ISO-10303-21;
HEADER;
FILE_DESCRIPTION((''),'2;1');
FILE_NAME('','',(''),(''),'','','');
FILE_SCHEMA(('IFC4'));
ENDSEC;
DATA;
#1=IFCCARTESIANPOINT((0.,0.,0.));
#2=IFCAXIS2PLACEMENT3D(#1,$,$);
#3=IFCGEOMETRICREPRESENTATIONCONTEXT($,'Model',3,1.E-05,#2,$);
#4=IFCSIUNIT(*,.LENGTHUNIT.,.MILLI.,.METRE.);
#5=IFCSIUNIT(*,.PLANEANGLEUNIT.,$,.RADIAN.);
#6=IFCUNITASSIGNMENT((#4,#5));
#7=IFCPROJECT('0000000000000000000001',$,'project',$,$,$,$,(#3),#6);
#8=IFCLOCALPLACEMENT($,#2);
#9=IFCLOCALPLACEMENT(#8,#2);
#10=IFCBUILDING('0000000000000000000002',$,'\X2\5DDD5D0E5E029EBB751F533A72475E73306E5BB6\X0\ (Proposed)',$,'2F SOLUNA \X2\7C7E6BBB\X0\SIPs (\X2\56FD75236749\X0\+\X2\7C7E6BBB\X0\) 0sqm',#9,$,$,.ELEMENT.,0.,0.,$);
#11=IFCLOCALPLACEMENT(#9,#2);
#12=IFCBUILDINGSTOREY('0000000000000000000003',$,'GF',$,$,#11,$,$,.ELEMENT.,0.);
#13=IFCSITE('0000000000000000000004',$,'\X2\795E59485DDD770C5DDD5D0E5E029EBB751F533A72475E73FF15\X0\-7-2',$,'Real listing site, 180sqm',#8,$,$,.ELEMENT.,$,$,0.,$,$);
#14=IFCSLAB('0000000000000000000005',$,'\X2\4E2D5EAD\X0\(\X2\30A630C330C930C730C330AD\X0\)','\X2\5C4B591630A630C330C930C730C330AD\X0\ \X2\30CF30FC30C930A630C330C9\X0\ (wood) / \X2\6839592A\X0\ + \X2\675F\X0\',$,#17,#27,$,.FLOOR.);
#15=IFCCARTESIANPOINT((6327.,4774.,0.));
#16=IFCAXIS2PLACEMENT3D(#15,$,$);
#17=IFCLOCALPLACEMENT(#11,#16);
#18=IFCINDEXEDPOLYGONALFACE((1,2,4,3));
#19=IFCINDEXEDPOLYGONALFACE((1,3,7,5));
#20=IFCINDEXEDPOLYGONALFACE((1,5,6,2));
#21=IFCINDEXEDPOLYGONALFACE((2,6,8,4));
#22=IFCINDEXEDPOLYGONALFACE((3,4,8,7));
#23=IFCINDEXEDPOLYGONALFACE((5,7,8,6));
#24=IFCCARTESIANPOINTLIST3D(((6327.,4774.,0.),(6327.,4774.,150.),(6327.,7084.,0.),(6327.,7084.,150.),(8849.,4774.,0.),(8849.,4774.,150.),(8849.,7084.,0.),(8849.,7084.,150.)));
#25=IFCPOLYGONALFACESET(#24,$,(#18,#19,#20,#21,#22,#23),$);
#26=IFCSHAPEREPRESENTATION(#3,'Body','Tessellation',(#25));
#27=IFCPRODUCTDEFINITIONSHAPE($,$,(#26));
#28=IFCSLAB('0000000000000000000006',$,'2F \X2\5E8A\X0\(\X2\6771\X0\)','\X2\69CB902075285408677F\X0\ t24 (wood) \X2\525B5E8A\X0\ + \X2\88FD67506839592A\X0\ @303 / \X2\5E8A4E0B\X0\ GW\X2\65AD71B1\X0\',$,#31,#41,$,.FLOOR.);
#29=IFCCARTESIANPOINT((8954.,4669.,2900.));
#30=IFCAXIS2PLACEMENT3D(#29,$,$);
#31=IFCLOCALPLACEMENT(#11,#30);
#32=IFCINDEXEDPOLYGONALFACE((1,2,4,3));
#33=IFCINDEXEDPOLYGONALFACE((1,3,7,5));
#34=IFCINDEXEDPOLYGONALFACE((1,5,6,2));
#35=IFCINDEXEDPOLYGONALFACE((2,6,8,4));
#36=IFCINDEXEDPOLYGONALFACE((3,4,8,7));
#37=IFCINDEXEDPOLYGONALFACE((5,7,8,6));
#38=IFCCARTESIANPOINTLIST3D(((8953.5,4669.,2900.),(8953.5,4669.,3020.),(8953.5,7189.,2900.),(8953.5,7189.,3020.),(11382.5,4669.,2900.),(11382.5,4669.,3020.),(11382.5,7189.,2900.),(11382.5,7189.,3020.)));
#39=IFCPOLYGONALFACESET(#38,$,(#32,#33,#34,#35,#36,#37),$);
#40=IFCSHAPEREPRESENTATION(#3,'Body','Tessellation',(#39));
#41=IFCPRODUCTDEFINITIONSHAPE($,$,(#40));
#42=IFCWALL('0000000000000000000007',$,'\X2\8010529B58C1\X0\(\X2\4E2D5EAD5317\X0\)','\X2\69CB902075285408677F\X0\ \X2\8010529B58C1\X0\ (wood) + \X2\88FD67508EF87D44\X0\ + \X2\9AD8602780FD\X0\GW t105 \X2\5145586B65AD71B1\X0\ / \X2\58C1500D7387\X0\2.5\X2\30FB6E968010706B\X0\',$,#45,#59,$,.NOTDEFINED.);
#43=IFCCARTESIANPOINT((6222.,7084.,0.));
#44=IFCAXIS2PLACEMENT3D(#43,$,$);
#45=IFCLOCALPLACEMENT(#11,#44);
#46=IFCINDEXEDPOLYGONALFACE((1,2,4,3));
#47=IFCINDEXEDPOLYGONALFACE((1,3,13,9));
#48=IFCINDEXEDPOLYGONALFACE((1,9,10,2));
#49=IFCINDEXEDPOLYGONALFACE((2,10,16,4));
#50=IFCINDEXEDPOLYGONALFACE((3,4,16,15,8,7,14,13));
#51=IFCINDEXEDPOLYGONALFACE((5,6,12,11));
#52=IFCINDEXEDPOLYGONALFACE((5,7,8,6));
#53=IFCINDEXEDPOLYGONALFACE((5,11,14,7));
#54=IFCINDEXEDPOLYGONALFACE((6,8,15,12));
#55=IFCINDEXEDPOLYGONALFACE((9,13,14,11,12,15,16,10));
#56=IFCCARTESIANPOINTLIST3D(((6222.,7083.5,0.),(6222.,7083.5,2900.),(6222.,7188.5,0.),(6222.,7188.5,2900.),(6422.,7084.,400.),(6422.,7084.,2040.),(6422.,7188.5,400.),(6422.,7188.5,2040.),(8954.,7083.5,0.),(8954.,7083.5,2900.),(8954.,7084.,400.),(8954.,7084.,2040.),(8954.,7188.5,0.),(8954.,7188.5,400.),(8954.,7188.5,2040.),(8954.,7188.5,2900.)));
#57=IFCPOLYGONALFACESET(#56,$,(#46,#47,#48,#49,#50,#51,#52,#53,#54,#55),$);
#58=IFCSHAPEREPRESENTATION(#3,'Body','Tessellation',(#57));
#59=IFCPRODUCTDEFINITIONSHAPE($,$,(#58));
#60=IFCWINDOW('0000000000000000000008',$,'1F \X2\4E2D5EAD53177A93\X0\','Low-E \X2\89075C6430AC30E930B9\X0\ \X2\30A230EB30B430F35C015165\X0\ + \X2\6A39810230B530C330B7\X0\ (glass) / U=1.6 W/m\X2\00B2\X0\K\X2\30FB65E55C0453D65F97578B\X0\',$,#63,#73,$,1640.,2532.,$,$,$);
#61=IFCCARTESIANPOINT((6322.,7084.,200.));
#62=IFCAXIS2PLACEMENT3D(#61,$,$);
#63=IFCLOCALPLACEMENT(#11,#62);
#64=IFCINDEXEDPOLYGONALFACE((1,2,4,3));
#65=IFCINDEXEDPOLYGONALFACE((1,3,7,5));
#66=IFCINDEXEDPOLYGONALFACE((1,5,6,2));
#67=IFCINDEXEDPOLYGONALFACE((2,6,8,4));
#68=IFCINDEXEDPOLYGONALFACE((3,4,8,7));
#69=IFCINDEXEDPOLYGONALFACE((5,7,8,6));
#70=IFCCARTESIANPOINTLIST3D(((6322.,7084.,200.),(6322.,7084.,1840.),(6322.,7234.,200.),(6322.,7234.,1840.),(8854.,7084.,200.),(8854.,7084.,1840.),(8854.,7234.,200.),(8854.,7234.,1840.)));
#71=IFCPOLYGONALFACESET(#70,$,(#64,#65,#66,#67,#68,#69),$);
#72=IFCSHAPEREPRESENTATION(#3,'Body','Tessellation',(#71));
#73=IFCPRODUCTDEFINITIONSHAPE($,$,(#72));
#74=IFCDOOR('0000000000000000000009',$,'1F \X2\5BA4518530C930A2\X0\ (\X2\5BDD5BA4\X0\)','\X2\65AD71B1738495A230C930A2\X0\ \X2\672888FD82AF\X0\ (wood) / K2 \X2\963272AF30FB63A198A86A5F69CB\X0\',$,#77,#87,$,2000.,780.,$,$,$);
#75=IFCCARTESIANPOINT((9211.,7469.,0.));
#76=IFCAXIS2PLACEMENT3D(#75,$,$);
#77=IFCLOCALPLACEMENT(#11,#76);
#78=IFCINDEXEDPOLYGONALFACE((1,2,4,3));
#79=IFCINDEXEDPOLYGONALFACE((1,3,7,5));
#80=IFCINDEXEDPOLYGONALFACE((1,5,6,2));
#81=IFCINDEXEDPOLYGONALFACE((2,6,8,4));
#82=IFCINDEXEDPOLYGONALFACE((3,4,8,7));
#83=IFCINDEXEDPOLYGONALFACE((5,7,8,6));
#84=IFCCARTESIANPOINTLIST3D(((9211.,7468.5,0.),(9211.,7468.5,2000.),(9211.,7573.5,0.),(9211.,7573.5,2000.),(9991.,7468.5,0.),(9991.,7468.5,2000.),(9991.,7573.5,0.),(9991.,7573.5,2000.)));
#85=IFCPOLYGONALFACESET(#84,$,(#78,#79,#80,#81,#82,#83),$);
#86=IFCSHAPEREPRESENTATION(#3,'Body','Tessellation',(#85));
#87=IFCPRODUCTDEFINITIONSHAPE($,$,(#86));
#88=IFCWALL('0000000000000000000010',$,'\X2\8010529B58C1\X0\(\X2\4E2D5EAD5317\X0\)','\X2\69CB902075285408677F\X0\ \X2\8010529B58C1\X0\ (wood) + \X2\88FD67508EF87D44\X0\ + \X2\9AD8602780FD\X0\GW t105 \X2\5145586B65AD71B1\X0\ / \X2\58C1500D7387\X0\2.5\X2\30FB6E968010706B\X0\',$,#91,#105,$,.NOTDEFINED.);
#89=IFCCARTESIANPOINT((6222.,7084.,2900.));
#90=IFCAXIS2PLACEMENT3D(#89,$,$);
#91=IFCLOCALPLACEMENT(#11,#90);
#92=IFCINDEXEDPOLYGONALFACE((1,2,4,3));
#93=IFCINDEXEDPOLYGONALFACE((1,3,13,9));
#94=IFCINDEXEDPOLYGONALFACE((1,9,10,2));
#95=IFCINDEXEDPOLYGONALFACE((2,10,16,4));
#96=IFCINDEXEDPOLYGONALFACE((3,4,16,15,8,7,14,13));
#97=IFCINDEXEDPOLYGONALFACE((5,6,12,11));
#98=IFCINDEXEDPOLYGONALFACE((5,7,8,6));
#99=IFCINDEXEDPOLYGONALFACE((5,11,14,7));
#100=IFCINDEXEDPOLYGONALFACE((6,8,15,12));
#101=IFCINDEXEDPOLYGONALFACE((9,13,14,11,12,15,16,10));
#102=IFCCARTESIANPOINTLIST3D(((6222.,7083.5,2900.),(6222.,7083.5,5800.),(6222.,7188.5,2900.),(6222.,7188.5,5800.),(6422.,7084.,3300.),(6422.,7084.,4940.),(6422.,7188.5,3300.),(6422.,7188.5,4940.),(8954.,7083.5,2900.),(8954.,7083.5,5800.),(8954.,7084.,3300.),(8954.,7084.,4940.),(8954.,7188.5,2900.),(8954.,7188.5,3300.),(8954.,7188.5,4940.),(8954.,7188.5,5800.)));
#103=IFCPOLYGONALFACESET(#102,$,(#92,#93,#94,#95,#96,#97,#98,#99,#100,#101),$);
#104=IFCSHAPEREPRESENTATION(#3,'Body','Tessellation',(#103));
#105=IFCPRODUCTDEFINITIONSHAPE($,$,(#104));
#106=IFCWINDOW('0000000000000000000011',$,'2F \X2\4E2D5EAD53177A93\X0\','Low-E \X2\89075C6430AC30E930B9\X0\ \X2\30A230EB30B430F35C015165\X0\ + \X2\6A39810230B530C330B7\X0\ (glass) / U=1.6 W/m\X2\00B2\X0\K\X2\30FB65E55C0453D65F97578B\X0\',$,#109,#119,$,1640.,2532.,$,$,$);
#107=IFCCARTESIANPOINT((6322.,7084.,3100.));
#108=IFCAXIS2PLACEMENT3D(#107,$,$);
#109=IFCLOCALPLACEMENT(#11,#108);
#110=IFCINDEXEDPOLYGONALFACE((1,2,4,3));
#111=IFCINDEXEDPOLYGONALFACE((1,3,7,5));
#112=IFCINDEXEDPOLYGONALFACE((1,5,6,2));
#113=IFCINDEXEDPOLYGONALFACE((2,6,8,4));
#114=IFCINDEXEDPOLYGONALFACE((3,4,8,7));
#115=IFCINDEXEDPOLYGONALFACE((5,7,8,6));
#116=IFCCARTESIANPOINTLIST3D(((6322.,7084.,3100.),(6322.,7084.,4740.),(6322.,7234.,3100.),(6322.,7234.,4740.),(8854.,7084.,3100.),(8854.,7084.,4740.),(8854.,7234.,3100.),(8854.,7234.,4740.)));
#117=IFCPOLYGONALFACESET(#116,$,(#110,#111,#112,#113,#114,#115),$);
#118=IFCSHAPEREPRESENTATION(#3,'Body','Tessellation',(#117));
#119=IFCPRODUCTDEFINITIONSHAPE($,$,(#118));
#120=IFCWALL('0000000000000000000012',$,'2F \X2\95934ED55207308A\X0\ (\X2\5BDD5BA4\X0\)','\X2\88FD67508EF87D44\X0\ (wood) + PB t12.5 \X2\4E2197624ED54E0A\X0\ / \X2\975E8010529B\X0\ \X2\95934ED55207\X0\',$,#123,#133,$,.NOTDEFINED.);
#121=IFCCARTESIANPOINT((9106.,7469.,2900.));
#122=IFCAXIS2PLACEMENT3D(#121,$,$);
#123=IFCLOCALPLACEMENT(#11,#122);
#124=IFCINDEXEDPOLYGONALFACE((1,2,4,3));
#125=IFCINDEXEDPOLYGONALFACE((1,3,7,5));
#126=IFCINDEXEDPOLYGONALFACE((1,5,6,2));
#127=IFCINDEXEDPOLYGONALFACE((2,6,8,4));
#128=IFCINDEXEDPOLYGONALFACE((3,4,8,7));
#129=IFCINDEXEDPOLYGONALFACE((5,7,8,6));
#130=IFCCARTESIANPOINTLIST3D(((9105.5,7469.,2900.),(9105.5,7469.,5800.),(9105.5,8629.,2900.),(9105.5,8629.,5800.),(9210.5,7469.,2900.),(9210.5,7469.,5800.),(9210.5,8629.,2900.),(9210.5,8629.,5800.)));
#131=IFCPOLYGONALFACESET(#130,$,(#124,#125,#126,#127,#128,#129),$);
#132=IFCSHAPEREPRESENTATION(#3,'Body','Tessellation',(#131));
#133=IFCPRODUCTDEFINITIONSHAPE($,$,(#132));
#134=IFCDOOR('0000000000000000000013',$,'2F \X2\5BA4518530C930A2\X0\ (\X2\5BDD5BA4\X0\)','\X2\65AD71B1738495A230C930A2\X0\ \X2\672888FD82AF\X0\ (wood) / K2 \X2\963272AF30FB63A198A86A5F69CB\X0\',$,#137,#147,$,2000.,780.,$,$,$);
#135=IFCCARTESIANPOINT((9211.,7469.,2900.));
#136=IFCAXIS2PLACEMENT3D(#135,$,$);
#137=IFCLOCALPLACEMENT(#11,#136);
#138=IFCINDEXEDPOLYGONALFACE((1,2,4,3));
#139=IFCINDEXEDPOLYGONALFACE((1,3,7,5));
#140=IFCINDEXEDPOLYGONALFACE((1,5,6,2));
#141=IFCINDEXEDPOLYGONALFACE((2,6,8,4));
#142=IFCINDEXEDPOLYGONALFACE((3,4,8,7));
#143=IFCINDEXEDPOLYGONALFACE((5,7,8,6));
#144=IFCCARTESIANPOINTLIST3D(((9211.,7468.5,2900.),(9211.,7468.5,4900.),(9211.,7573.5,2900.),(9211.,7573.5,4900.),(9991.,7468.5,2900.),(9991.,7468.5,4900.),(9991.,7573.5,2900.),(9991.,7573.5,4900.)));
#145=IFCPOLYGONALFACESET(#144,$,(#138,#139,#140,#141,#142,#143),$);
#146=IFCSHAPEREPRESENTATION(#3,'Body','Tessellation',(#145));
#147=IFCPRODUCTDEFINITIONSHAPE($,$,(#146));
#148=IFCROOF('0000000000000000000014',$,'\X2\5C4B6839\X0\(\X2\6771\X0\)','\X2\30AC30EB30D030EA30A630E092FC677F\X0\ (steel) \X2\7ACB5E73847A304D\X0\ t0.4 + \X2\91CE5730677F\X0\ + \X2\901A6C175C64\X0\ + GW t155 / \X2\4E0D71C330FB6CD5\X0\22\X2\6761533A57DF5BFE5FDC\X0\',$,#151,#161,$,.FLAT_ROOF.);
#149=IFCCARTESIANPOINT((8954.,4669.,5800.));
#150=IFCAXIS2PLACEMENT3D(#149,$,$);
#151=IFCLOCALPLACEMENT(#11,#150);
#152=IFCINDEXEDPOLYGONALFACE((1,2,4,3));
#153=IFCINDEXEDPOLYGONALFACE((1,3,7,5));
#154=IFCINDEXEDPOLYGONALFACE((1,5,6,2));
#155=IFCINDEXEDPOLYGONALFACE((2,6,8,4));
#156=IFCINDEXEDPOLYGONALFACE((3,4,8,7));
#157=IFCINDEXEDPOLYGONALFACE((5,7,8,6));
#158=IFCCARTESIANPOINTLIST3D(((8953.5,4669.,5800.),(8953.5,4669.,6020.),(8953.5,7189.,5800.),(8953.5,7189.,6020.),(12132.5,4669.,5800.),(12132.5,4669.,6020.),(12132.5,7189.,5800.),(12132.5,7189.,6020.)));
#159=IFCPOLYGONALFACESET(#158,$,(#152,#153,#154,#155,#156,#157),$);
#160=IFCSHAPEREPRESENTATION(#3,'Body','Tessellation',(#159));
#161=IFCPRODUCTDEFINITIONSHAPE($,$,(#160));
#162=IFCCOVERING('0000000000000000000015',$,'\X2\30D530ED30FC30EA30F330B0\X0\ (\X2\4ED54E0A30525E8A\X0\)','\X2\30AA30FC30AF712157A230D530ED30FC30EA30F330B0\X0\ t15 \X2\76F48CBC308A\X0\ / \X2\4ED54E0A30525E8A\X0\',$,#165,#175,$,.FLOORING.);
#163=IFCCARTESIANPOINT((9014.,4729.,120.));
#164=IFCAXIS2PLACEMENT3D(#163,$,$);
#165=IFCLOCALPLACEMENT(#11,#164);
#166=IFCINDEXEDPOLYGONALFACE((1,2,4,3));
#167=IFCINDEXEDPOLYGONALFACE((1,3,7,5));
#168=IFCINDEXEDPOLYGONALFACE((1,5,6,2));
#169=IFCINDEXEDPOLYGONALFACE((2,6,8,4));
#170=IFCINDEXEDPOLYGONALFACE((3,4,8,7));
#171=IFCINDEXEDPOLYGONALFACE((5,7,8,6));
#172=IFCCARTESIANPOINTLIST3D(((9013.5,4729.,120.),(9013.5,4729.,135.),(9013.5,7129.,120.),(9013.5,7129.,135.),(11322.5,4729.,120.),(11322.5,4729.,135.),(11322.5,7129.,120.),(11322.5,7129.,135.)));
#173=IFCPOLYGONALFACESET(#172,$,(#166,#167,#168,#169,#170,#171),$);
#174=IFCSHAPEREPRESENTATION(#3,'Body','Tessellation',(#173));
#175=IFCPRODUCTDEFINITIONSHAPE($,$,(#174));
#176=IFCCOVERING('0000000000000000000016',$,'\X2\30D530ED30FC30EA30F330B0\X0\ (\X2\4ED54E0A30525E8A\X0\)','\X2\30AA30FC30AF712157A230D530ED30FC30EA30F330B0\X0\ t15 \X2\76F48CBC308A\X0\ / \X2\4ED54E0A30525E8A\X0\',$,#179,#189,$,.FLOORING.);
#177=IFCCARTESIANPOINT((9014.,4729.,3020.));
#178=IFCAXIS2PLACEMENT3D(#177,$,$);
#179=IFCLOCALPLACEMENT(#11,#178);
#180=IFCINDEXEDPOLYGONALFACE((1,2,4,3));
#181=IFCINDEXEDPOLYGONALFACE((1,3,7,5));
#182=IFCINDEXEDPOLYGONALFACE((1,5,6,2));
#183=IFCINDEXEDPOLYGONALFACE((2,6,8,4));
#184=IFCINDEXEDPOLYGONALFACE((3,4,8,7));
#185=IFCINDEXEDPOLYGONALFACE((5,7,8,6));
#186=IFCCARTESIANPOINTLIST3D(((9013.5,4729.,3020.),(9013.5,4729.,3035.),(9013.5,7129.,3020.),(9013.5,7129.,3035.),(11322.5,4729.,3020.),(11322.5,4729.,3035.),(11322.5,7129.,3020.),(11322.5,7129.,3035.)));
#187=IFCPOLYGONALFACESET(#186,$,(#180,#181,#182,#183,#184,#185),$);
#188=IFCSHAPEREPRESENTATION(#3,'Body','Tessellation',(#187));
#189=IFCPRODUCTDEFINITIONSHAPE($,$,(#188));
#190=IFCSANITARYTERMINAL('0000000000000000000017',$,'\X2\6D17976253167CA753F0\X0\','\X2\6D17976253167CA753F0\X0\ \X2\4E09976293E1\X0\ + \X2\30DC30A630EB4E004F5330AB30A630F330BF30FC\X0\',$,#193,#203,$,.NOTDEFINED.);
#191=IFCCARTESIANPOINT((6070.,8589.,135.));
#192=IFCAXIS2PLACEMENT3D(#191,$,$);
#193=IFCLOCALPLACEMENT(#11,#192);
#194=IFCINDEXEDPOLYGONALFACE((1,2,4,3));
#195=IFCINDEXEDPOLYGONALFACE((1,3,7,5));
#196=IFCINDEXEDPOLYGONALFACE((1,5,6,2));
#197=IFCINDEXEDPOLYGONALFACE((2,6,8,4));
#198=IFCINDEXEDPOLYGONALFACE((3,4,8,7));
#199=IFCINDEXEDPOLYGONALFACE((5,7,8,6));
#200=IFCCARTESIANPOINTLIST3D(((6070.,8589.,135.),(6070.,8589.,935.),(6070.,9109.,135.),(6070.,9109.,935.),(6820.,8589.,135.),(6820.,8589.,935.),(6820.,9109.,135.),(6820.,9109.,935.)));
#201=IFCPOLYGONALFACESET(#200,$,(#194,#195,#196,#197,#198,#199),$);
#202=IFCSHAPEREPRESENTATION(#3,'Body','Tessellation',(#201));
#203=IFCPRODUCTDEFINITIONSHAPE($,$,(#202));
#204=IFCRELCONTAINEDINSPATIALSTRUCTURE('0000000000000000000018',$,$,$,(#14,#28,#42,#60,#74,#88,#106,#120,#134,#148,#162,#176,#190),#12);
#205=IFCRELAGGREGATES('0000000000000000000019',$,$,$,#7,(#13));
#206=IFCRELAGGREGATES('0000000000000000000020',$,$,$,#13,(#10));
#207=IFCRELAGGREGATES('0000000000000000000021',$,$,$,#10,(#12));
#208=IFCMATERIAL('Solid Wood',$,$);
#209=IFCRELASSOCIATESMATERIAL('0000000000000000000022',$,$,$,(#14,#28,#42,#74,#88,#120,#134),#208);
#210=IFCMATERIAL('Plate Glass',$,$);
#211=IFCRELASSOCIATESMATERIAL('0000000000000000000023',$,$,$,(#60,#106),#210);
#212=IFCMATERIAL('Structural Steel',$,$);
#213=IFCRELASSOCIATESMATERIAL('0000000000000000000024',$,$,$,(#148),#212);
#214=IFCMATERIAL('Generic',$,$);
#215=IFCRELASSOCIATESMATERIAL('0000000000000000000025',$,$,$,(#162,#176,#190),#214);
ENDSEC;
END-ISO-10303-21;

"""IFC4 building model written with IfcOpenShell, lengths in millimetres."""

from ifc_helpers import new_model, si_unit, frame, frame_2d, origin, place, context, project, spatial, rectangle, extrude, material, element, fill, save


model = new_model("IFC4")

# Units and contexts
model_context = context("Model", 3, precision=1e-05, world=origin())
ifc_project = project(units=[si_unit("LENGTHUNIT", "METRE", prefix="MILLI"), si_unit("PLANEANGLEUNIT", "RADIAN")], contexts=[model_context])

# Site, building, storey
site_placement = place(None, origin())
site = spatial("IfcSite", under=ifc_project, at=site_placement, Name="神奈川県川崎市麻生区片平５-7-2", ObjectType="Real listing site, 180sqm", CompositionType="ELEMENT", RefElevation=0.0)
building_placement = place(site_placement, origin())
building = spatial("IfcBuilding", under=site, at=building_placement, Name="川崎市麻生区片平の家 (Proposed)", ObjectType="2F SOLUNA 籾殻SIPs (国産杉+籾殻) 0sqm", CompositionType="ELEMENT", ElevationOfRefHeight=0.0, ElevationOfTerrain=0.0)
storey_placement = place(building_placement, origin())
storey = spatial("IfcBuildingStorey", under=building, at=storey_placement, Name="GF", CompositionType="ELEMENT", Elevation=0.0)

# Slabs
ifc_material_1 = material(Name="Solid Wood")
slab_1_placement = place(storey_placement, frame((6327.0, 4774.0, 0.0)))
element("IfcSlab", 1, at=slab_1_placement, inside=storey, material=ifc_material_1, Name="中庭(ウッドデッキ)", Description="屋外ウッドデッキ ハードウッド (wood) / 根太 + 束", PredefinedType="FLOOR", context=model_context, shape_type="SweptSolid", body=[
    extrude(rectangle(XDim=2522.0, YDim=2310.0, at=frame_2d((1261.0, 1155.0))), frame((6327.0, 4774.0, 0.0)), (0.0, 0.0, 1.0), 150.0),
])
slab_2_placement = place(storey_placement, frame((8954.0, 4669.0, 2900.0)))
element("IfcSlab", 2, at=slab_2_placement, inside=storey, material=ifc_material_1, Name="2F 床(東)", Description="構造用合板 t24 (wood) 剛床 + 製材根太 @303 / 床下 GW断熱", PredefinedType="FLOOR", context=model_context, shape_type="SweptSolid", body=[
    extrude(rectangle(XDim=2429.0, YDim=2520.0, at=frame_2d((1214.0, 1260.0))), frame((8954.0, 4669.0, 2900.0)), (0.0, 0.0, 1.0), 120.0),
])

# Wall, opening, window
wall_1_placement = place(storey_placement, frame((6222.0, 7084.0, 0.0)))
wall_1 = element("IfcWall", 3, at=wall_1_placement, inside=storey, material=ifc_material_1, Name="耐力壁(中庭北)", Description="構造用合板 耐力壁 (wood) + 製材軸組 + 高性能GW t105 充填断熱 / 壁倍率2.5・準耐火", PredefinedType="NOTDEFINED", context=model_context, shape_type="SweptSolid", body=[
    extrude(rectangle(XDim=2732.0, YDim=105.0, at=frame_2d((1366.0, 52.0))), frame((6222.0, 7084.0, 0.0)), (0.0, 0.0, 1.0), 2900.0),
])
opening_1_placement = place(storey_placement, frame((6322.0, 7084.0, 200.0)))
opening_1 = element("IfcOpeningElement", 4, at=opening_1_placement, cuts=wall_1, PredefinedType="NOTDEFINED", context=model_context, shape_type="SweptSolid", body=[
    extrude(rectangle(XDim=2532.0, YDim=150.0, at=frame_2d((1266.0, 75.0))), frame((6322.0, 7084.0, 200.0)), (0.0, 0.0, 1.0), 1640.0),
])
ifc_material_2 = material(Name="Plate Glass")
window_1_placement = place(storey_placement, frame((6322.0, 7084.0, 200.0)))
window_1 = element("IfcWindow", 5, at=window_1_placement, inside=storey, material=ifc_material_2, Name="1F 中庭北窓", Description="Low-E 複層ガラス アルゴン封入 + 樹脂サッシ (glass) / U=1.6 W/m²K・日射取得型", OverallHeight=1640.0, OverallWidth=2532.0, context=model_context, shape_type="SweptSolid", body=[
    extrude(rectangle(XDim=2532.0, YDim=150.0, at=frame_2d((1266.0, 75.0))), frame((6322.0, 7084.0, 200.0)), (0.0, 0.0, 1.0), 1640.0),
])
fill(opening_1, window_1)

# Door
door_1_placement = place(storey_placement, frame((9211.0, 7469.0, 0.0)))
element("IfcDoor", 6, at=door_1_placement, inside=storey, material=ifc_material_1, Name="1F 室内ドア (寝室)", Description="断熱玄関ドア 木製芯 (wood) / K2 防犯・採風機構", OverallHeight=2000.0, OverallWidth=780.0, context=model_context, shape_type="SweptSolid", body=[
    extrude(rectangle(XDim=780.0, YDim=105.0, at=frame_2d((390.0, 52.0))), frame((9211.0, 7469.0, 0.0)), (0.0, 0.0, 1.0), 2000.0),
])

# Wall, opening, window
wall_2_placement = place(storey_placement, frame((6222.0, 7084.0, 2900.0)))
wall_2 = element("IfcWall", 7, at=wall_2_placement, inside=storey, material=ifc_material_1, Name="耐力壁(中庭北)", Description="構造用合板 耐力壁 (wood) + 製材軸組 + 高性能GW t105 充填断熱 / 壁倍率2.5・準耐火", PredefinedType="NOTDEFINED", context=model_context, shape_type="SweptSolid", body=[
    extrude(rectangle(XDim=2732.0, YDim=105.0, at=frame_2d((1366.0, 52.0))), frame((6222.0, 7084.0, 2900.0)), (0.0, 0.0, 1.0), 2900.0),
])
opening_2_placement = place(storey_placement, frame((6322.0, 7084.0, 3100.0)))
opening_2 = element("IfcOpeningElement", 8, at=opening_2_placement, cuts=wall_2, PredefinedType="NOTDEFINED", context=model_context, shape_type="SweptSolid", body=[
    extrude(rectangle(XDim=2532.0, YDim=150.0, at=frame_2d((1266.0, 75.0))), frame((6322.0, 7084.0, 3100.0)), (0.0, 0.0, 1.0), 1640.0),
])
window_2_placement = place(storey_placement, frame((6322.0, 7084.0, 3100.0)))
window_2 = element("IfcWindow", 9, at=window_2_placement, inside=storey, material=ifc_material_2, Name="2F 中庭北窓", Description="Low-E 複層ガラス アルゴン封入 + 樹脂サッシ (glass) / U=1.6 W/m²K・日射取得型", OverallHeight=1640.0, OverallWidth=2532.0, context=model_context, shape_type="SweptSolid", body=[
    extrude(rectangle(XDim=2532.0, YDim=150.0, at=frame_2d((1266.0, 75.0))), frame((6322.0, 7084.0, 3100.0)), (0.0, 0.0, 1.0), 1640.0),
])
fill(opening_2, window_2)

# Wall
wall_3_placement = place(storey_placement, frame((9106.0, 7469.0, 2900.0)))
element("IfcWall", 10, at=wall_3_placement, inside=storey, material=ifc_material_1, Name="2F 間仕切り (寝室)", Description="製材軸組 (wood) + PB t12.5 両面仕上 / 非耐力 間仕切", PredefinedType="NOTDEFINED", context=model_context, shape_type="SweptSolid", body=[
    extrude(rectangle(XDim=105.0, YDim=1160.0, at=frame_2d((52.0, 580.0))), frame((9106.0, 7469.0, 2900.0)), (0.0, 0.0, 1.0), 2900.0),
])

# Door
door_2_placement = place(storey_placement, frame((9211.0, 7469.0, 2900.0)))
element("IfcDoor", 11, at=door_2_placement, inside=storey, material=ifc_material_1, Name="2F 室内ドア (寝室)", Description="断熱玄関ドア 木製芯 (wood) / K2 防犯・採風機構", OverallHeight=2000.0, OverallWidth=780.0, context=model_context, shape_type="SweptSolid", body=[
    extrude(rectangle(XDim=780.0, YDim=105.0, at=frame_2d((390.0, 52.0))), frame((9211.0, 7469.0, 2900.0)), (0.0, 0.0, 1.0), 2000.0),
])

# Roof
ifc_material_3 = material(Name="Structural Steel")
for number, where, name in (
    (12, (8954.0, 4669.0, 5800.0), "屋根(東)"),
):
    element("IfcRoof", number, at=place(storey_placement, frame(where)), inside=storey, material=ifc_material_3, Name=name, Description="ガルバリウム鋼板 (steel) 立平葺き t0.4 + 野地板 + 通気層 + GW t155 / 不燃・法22条区域対応", PredefinedType="FLAT_ROOF", context=model_context, shape_type="SweptSolid", body=[
        extrude(rectangle(XDim=3179.0, YDim=2520.0, at=frame_2d((1589.0, 1260.0))), frame((8954.0, 4669.0, 5800.0)), (0.0, 0.0, 1.0), 220.0),
    ])

# Coverings
ifc_material_4 = material(Name="Generic")
covering_1_placement = place(storey_placement, frame((9014.0, 4729.0, 120.0)))
element("IfcCovering", 13, at=covering_1_placement, inside=storey, material=ifc_material_4, Name="フローリング (仕上げ床)", Description="オーク無垢フローリング t15 直貼り / 仕上げ床", PredefinedType="FLOORING", context=model_context, shape_type="SweptSolid", body=[
    extrude(rectangle(XDim=2309.0, YDim=2400.0, at=frame_2d((1154.0, 1200.0))), frame((9014.0, 4729.0, 120.0)), (0.0, 0.0, 1.0), 15.0),
])
covering_2_placement = place(storey_placement, frame((9014.0, 4729.0, 3020.0)))
element("IfcCovering", 14, at=covering_2_placement, inside=storey, material=ifc_material_4, Name="フローリング (仕上げ床)", Description="オーク無垢フローリング t15 直貼り / 仕上げ床", PredefinedType="FLOORING", context=model_context, shape_type="SweptSolid", body=[
    extrude(rectangle(XDim=2309.0, YDim=2400.0, at=frame_2d((1154.0, 1200.0))), frame((9014.0, 4729.0, 3020.0)), (0.0, 0.0, 1.0), 15.0),
])

# Sanitary terminal
sanitary_terminal_1_placement = place(storey_placement, frame((6070.0, 8589.0, 135.0)))
element("IfcSanitaryTerminal", 15, at=sanitary_terminal_1_placement, inside=storey, material=ifc_material_4, Name="洗面化粧台", Description="洗面化粧台 三面鏡 + ボウル一体カウンター", PredefinedType="NOTDEFINED", context=model_context, shape_type="SweptSolid", body=[
    extrude(rectangle(XDim=750.0, YDim=520.0, at=frame_2d((375.0, 260.0))), frame((6070.0, 8589.0, 135.0)), (0.0, 0.0, 1.0), 800.0),
])

save(model, "model.ifc")
